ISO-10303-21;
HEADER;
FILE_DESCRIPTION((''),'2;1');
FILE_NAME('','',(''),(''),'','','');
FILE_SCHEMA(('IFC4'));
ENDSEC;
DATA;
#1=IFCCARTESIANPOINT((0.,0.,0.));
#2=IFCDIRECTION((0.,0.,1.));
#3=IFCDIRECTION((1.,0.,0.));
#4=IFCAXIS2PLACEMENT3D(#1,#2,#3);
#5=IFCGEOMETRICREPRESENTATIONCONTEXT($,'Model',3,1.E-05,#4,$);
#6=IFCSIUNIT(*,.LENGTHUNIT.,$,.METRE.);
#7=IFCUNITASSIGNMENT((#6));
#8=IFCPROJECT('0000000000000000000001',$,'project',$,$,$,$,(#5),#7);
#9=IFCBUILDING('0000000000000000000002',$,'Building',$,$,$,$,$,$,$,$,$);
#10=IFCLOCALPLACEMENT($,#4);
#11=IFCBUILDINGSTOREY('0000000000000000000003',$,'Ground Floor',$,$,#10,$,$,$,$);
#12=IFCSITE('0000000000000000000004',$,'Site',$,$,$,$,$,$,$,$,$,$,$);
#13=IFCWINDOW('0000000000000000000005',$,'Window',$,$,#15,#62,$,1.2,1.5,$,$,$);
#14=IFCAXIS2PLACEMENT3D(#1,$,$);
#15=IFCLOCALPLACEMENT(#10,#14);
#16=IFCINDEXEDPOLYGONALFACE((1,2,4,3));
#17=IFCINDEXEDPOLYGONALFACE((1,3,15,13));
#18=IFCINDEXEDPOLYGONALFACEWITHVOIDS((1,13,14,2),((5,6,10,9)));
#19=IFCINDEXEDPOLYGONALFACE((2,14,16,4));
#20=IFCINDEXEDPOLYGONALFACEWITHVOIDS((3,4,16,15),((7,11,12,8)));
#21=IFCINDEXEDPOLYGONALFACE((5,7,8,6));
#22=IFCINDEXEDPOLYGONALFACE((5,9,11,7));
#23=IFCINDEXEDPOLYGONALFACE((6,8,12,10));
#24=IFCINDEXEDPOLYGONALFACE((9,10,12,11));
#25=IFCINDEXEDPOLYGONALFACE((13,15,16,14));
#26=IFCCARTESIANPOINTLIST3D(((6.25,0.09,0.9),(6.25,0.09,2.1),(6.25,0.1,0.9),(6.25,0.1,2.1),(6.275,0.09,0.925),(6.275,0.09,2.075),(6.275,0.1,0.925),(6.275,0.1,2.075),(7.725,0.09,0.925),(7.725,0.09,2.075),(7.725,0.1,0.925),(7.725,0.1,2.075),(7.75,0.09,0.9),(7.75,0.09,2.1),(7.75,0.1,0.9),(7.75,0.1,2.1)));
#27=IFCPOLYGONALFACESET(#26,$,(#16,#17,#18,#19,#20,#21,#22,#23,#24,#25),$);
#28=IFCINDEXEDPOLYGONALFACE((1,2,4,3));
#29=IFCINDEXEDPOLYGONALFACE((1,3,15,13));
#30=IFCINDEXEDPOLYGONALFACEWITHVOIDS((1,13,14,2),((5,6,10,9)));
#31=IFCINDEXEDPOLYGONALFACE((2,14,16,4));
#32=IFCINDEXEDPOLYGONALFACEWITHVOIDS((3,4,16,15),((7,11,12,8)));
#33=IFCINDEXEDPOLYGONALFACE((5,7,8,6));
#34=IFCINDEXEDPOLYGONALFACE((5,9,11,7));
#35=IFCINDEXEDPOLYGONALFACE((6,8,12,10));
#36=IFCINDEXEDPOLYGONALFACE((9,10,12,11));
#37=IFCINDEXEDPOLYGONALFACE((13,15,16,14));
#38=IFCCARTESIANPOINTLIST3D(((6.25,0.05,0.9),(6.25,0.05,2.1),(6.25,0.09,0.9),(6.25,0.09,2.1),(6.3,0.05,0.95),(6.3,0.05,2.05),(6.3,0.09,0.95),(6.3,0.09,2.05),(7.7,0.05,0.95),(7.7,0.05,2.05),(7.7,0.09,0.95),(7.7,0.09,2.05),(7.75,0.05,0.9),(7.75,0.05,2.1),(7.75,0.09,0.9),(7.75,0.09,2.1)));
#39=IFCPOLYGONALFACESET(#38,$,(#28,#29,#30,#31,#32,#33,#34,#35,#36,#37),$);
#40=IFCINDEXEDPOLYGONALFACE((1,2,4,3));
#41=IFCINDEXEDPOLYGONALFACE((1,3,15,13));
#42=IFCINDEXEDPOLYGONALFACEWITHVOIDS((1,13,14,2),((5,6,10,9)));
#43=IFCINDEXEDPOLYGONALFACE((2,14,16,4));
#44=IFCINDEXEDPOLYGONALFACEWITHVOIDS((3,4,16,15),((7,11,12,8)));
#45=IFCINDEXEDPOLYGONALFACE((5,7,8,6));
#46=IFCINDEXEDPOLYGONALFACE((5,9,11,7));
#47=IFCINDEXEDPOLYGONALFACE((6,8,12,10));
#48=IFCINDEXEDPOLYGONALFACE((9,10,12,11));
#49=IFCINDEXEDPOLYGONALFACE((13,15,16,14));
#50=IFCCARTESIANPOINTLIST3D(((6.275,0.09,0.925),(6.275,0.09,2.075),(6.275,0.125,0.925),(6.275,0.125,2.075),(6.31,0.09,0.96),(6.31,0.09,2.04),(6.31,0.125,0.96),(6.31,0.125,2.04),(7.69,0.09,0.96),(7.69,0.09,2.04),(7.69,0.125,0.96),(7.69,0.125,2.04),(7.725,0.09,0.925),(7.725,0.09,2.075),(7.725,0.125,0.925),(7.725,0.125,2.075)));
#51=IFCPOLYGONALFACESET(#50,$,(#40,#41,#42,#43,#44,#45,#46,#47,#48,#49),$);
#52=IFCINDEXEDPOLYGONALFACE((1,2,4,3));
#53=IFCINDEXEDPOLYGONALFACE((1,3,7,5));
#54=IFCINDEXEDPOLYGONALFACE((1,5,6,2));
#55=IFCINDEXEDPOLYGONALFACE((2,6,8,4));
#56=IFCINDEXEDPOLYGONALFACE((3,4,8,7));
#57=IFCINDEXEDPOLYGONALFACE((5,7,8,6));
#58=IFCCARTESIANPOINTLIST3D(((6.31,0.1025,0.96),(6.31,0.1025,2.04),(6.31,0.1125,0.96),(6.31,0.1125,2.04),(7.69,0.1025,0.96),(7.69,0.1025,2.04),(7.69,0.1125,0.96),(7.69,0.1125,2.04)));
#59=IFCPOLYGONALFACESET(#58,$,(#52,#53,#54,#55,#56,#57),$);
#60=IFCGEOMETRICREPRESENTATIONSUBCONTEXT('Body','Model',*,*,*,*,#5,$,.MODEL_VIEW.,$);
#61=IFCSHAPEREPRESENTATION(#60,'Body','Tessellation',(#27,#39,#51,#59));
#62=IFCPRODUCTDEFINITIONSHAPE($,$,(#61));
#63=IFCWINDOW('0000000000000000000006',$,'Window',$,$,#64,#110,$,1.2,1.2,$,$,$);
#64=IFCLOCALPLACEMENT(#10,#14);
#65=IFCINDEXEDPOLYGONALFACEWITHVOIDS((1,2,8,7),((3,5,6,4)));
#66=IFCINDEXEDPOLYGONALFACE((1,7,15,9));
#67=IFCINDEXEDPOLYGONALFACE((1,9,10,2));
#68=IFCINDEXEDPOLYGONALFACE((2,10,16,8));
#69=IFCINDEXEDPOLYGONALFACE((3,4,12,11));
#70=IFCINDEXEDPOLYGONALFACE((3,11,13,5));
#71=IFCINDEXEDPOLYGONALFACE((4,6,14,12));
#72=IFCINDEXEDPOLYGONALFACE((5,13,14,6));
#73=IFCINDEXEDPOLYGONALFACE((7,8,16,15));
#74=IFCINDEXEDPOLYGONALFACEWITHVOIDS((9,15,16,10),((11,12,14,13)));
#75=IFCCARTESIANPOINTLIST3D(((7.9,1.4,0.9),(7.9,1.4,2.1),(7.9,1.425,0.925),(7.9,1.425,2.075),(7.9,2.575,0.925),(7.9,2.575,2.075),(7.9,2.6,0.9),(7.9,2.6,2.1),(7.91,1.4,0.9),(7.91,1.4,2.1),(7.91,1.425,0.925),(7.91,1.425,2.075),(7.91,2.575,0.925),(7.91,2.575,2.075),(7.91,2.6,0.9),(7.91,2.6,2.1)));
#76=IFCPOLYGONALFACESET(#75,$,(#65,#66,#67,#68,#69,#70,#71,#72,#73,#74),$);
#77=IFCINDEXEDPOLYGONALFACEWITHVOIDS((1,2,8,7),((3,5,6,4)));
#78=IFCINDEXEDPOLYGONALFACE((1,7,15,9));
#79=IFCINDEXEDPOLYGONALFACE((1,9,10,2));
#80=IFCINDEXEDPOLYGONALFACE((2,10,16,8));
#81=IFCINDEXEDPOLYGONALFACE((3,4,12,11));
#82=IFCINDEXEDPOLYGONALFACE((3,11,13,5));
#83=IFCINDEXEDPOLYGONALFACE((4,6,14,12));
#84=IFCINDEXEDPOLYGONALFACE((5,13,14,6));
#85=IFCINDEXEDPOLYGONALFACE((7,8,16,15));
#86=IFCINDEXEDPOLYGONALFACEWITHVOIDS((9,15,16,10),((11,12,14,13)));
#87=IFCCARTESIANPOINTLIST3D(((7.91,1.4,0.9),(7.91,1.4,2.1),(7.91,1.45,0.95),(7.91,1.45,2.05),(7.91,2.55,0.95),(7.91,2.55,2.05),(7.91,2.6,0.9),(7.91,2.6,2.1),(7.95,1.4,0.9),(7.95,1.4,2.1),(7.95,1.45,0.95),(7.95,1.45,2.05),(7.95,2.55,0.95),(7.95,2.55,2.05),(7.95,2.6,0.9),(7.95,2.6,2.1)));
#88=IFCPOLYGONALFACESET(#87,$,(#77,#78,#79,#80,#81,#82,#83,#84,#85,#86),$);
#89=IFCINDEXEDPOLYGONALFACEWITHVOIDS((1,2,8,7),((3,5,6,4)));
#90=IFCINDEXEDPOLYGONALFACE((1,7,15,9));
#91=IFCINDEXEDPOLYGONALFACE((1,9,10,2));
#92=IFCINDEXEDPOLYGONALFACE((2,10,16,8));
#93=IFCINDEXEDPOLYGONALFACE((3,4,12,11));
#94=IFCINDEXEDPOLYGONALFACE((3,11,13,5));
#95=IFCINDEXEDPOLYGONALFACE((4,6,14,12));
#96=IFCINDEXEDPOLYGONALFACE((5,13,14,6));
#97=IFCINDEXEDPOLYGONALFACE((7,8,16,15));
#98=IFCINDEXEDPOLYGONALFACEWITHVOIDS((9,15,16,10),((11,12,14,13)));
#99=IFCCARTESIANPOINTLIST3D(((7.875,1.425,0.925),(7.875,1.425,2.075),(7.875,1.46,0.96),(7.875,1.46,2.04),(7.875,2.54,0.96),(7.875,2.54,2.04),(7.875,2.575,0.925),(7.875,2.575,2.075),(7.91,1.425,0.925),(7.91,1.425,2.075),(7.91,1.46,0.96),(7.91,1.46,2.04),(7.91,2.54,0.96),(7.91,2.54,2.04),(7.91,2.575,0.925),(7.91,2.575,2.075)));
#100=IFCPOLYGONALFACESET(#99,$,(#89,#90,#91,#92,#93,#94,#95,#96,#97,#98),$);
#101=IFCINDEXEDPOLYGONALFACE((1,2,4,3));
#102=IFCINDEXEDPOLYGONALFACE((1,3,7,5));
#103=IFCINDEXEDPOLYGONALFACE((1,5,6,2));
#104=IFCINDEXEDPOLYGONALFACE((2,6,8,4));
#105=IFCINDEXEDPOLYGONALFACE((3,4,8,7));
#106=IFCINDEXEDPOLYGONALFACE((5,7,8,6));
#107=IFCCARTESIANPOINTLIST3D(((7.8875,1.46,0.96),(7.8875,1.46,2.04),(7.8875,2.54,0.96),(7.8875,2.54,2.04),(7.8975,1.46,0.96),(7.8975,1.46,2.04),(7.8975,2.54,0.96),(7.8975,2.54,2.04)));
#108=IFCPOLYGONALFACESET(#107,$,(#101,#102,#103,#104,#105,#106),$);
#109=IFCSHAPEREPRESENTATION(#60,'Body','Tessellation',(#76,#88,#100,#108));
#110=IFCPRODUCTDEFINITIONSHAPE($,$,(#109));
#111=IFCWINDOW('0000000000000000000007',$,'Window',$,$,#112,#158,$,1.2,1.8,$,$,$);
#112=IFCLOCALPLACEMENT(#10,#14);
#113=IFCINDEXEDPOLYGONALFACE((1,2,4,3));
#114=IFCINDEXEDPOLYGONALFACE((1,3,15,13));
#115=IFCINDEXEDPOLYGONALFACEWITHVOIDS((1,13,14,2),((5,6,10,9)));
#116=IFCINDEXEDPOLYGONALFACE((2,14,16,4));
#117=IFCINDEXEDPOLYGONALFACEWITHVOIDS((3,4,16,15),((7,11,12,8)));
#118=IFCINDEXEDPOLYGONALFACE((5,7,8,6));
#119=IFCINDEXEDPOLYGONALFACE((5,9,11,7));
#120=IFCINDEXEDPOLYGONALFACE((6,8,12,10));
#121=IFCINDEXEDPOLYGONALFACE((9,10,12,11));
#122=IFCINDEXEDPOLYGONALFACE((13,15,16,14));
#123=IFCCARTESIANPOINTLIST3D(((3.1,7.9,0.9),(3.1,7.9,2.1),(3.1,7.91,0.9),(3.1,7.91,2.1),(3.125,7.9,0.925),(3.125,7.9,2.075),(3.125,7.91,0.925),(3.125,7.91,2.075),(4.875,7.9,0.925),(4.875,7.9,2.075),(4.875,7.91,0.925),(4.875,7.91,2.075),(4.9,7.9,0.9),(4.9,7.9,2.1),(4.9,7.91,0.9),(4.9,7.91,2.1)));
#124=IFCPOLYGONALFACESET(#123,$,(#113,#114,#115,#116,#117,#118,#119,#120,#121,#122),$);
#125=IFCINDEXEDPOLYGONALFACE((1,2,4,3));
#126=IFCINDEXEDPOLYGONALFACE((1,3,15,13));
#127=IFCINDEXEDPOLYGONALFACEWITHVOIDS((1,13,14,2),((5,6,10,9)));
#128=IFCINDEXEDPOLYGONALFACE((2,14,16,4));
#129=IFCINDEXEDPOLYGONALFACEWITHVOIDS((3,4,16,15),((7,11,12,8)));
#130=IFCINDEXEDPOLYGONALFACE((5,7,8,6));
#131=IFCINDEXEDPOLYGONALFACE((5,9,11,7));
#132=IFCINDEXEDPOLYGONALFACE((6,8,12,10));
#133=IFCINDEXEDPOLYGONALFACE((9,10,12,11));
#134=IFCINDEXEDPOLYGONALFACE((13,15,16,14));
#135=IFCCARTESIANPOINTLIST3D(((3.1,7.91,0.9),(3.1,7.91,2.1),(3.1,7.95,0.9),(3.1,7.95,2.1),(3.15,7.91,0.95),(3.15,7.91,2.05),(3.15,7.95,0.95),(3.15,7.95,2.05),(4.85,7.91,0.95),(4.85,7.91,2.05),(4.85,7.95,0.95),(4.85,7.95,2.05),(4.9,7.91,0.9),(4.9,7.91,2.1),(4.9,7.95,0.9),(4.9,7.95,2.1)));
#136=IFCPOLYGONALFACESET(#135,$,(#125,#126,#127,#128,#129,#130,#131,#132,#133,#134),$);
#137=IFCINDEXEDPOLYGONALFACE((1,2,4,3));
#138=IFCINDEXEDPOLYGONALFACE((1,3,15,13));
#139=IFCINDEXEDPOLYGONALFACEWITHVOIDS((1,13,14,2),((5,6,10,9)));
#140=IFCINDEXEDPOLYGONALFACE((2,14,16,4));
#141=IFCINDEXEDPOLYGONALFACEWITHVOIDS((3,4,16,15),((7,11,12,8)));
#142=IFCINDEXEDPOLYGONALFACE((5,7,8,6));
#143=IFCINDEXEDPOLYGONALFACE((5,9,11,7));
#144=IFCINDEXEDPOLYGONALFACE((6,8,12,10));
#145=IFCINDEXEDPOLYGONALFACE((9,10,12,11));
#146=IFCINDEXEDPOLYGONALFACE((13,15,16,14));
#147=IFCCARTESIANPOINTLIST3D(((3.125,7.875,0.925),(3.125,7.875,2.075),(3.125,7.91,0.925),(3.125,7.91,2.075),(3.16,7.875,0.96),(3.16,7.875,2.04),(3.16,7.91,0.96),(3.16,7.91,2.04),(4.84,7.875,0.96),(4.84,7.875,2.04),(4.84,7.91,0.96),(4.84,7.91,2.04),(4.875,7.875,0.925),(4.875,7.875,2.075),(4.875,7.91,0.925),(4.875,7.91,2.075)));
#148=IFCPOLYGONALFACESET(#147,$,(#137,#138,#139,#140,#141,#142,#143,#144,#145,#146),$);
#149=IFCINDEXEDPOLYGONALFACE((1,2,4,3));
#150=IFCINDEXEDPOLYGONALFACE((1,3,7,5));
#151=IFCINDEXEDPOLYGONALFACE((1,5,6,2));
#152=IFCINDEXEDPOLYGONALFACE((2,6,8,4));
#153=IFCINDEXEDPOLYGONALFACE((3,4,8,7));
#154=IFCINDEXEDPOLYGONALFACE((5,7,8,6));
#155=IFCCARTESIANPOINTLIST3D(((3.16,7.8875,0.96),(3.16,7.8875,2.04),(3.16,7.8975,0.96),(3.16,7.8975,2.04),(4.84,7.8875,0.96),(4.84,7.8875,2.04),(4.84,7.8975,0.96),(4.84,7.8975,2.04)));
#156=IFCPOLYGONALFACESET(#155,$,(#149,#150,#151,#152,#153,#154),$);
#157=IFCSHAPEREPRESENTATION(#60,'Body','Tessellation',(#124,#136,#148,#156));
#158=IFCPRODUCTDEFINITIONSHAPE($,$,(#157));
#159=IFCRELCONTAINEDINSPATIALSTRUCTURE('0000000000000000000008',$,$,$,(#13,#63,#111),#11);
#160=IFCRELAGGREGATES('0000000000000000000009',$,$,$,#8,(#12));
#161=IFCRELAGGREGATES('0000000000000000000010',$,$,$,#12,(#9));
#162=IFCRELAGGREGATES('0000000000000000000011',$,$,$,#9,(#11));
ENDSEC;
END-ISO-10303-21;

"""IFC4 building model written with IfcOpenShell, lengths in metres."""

from ifc_helpers import new_model, si_unit, frame, origin_with_axes, place, context, subcontext, project, spatial, line, indexed_curve, outline, extrude, element, save


model = new_model("IFC4")

# Units and contexts
model_context = context("Model", 3, precision=1e-05, world=origin_with_axes())
body_context = subcontext(model_context, "Body", "Model", "MODEL_VIEW")
ifc_project = project(units=[si_unit("LENGTHUNIT", "METRE")], contexts=[model_context])

# Site, building, storey
site = spatial("IfcSite", under=ifc_project, Name="Site")
building = spatial("IfcBuilding", under=site, Name="Building")
storey_placement = place(None, origin_with_axes())
storey = spatial("IfcBuildingStorey", under=building, at=storey_placement, Name="Ground Floor")

# Windows
window_1_placement = place(storey_placement, frame((6.25, 0.0, 0.9), z_axis=(0.0, 0.0, 1.0), x_axis=(1.0, 0.0, 0.0)))
element("IfcWindow", 1, at=window_1_placement, inside=storey, Name="Window", OverallHeight=1.2, OverallWidth=1.5, context=body_context, shape_type="SweptSolid", body=[
    extrude(outline(indexed_curve([(0.0, 0.0), (1.5, 0.0), (1.5, 1.2), (0.0, 1.2)], segments=[line(1, 2, 3, 4, 1)]), holes=[indexed_curve([(0.025, 0.025), (1.475, 0.025), (1.475, 1.175), (0.025, 1.175)], segments=[line(1, 2, 3, 4, 1)])]), frame((0.0, 0.09, 0.0), z_axis=(0.0, -1.0, 0.0), x_axis=(1.0, 0.0, 0.0)), (0.0, 0.0, -1.0), 0.01),
    extrude(outline(indexed_curve([(0.0, 0.0), (1.5, 0.0), (1.5, 1.2), (0.0, 1.2)], segments=[line(1, 2, 3, 4, 1)]), holes=[indexed_curve([(0.05, 0.05), (1.45, 0.05), (1.45, 1.15), (0.05, 1.15)], segments=[line(1, 2, 3, 4, 1)])]), frame((0.0, 0.05, 0.0), z_axis=(0.0, -1.0, 0.0), x_axis=(1.0, 0.0, 0.0)), (0.0, 0.0, -1.0), 0.04),
    extrude(outline(indexed_curve([(0.0, 0.0), (1.45, 0.0), (1.45, 1.15), (0.0, 1.15)], segments=[line(1, 2, 3, 4, 1)]), holes=[indexed_curve([(0.035, 0.035), (1.415, 0.035), (1.415, 1.115), (0.035, 1.115)], segments=[line(1, 2, 3, 4, 1)])]), frame((0.025, 0.09, 0.025), z_axis=(0.0, -1.0, 0.0), x_axis=(1.0, 0.0, 0.0)), (0.0, 0.0, -1.0), 0.035),
    extrude(outline(indexed_curve([(0.035, 0.035), (1.415, 0.035), (1.415, 1.115), (0.035, 1.115)], segments=[line(1, 2, 3, 4, 1)])), frame((0.025, 0.1025, 0.025), z_axis=(0.0, -1.0, 0.0), x_axis=(1.0, 0.0, 0.0)), (0.0, 0.0, -1.0), 0.01),
])
window_2_placement = place(storey_placement, frame((8.0, 1.4, 0.9), z_axis=(0.0, 0.0, 1.0), x_axis=(0.0, 1.0, 0.0)))
element("IfcWindow", 2, at=window_2_placement, inside=storey, Name="Window", OverallHeight=1.2, OverallWidth=1.2, context=body_context, shape_type="SweptSolid", body=[
    extrude(outline(indexed_curve([(0.0, 0.0), (1.2, 0.0), (1.2, 1.2), (0.0, 1.2)], segments=[line(1, 2, 3, 4, 1)]), holes=[indexed_curve([(0.025, 0.025), (1.175, 0.025), (1.175, 1.175), (0.025, 1.175)], segments=[line(1, 2, 3, 4, 1)])]), frame((0.0, 0.09, 0.0), z_axis=(0.0, -1.0, 0.0), x_axis=(1.0, 0.0, 0.0)), (0.0, 0.0, -1.0), 0.01),
    extrude(outline(indexed_curve([(0.0, 0.0), (1.2, 0.0), (1.2, 1.2), (0.0, 1.2)], segments=[line(1, 2, 3, 4, 1)]), holes=[indexed_curve([(0.05, 0.05), (1.15, 0.05), (1.15, 1.15), (0.05, 1.15)], segments=[line(1, 2, 3, 4, 1)])]), frame((0.0, 0.05, 0.0), z_axis=(0.0, -1.0, 0.0), x_axis=(1.0, 0.0, 0.0)), (0.0, 0.0, -1.0), 0.04),
    extrude(outline(indexed_curve([(0.0, 0.0), (1.15, 0.0), (1.15, 1.15), (0.0, 1.15)], segments=[line(1, 2, 3, 4, 1)]), holes=[indexed_curve([(0.035, 0.035), (1.115, 0.035), (1.115, 1.115), (0.035, 1.115)], segments=[line(1, 2, 3, 4, 1)])]), frame((0.025, 0.09, 0.025), z_axis=(0.0, -1.0, 0.0), x_axis=(1.0, 0.0, 0.0)), (0.0, 0.0, -1.0), 0.035),
    extrude(outline(indexed_curve([(0.035, 0.035), (1.115, 0.035), (1.115, 1.115), (0.035, 1.115)], segments=[line(1, 2, 3, 4, 1)])), frame((0.025, 0.1025, 0.025), z_axis=(0.0, -1.0, 0.0), x_axis=(1.0, 0.0, 0.0)), (0.0, 0.0, -1.0), 0.01),
])
window_3_placement = place(storey_placement, frame((4.9, 8.0, 0.9), z_axis=(0.0, 0.0, 1.0), x_axis=(-1.0, 0.0, 0.0)))
element("IfcWindow", 3, at=window_3_placement, inside=storey, Name="Window", OverallHeight=1.2, OverallWidth=1.8, context=body_context, shape_type="SweptSolid", body=[
    extrude(outline(indexed_curve([(0.0, 0.0), (1.8, 0.0), (1.8, 1.2), (0.0, 1.2)], segments=[line(1, 2, 3, 4, 1)]), holes=[indexed_curve([(0.025, 0.025), (1.775, 0.025), (1.775, 1.175), (0.025, 1.175)], segments=[line(1, 2, 3, 4, 1)])]), frame((0.0, 0.09, 0.0), z_axis=(0.0, -1.0, 0.0), x_axis=(1.0, 0.0, 0.0)), (0.0, 0.0, -1.0), 0.01),
    extrude(outline(indexed_curve([(0.0, 0.0), (1.8, 0.0), (1.8, 1.2), (0.0, 1.2)], segments=[line(1, 2, 3, 4, 1)]), holes=[indexed_curve([(0.05, 0.05), (1.75, 0.05), (1.75, 1.15), (0.05, 1.15)], segments=[line(1, 2, 3, 4, 1)])]), frame((0.0, 0.05, 0.0), z_axis=(0.0, -1.0, 0.0), x_axis=(1.0, 0.0, 0.0)), (0.0, 0.0, -1.0), 0.04),
    extrude(outline(indexed_curve([(0.0, 0.0), (1.75, 0.0), (1.75, 1.15), (0.0, 1.15)], segments=[line(1, 2, 3, 4, 1)]), holes=[indexed_curve([(0.035, 0.035), (1.715, 0.035), (1.715, 1.115), (0.035, 1.115)], segments=[line(1, 2, 3, 4, 1)])]), frame((0.025, 0.09, 0.025), z_axis=(0.0, -1.0, 0.0), x_axis=(1.0, 0.0, 0.0)), (0.0, 0.0, -1.0), 0.035),
    extrude(outline(indexed_curve([(0.035, 0.035), (1.715, 0.035), (1.715, 1.115), (0.035, 1.115)], segments=[line(1, 2, 3, 4, 1)])), frame((0.025, 0.1025, 0.025), z_axis=(0.0, -1.0, 0.0), x_axis=(1.0, 0.0, 0.0)), (0.0, 0.0, -1.0), 0.01),
])

save(model, "model.ifc")
